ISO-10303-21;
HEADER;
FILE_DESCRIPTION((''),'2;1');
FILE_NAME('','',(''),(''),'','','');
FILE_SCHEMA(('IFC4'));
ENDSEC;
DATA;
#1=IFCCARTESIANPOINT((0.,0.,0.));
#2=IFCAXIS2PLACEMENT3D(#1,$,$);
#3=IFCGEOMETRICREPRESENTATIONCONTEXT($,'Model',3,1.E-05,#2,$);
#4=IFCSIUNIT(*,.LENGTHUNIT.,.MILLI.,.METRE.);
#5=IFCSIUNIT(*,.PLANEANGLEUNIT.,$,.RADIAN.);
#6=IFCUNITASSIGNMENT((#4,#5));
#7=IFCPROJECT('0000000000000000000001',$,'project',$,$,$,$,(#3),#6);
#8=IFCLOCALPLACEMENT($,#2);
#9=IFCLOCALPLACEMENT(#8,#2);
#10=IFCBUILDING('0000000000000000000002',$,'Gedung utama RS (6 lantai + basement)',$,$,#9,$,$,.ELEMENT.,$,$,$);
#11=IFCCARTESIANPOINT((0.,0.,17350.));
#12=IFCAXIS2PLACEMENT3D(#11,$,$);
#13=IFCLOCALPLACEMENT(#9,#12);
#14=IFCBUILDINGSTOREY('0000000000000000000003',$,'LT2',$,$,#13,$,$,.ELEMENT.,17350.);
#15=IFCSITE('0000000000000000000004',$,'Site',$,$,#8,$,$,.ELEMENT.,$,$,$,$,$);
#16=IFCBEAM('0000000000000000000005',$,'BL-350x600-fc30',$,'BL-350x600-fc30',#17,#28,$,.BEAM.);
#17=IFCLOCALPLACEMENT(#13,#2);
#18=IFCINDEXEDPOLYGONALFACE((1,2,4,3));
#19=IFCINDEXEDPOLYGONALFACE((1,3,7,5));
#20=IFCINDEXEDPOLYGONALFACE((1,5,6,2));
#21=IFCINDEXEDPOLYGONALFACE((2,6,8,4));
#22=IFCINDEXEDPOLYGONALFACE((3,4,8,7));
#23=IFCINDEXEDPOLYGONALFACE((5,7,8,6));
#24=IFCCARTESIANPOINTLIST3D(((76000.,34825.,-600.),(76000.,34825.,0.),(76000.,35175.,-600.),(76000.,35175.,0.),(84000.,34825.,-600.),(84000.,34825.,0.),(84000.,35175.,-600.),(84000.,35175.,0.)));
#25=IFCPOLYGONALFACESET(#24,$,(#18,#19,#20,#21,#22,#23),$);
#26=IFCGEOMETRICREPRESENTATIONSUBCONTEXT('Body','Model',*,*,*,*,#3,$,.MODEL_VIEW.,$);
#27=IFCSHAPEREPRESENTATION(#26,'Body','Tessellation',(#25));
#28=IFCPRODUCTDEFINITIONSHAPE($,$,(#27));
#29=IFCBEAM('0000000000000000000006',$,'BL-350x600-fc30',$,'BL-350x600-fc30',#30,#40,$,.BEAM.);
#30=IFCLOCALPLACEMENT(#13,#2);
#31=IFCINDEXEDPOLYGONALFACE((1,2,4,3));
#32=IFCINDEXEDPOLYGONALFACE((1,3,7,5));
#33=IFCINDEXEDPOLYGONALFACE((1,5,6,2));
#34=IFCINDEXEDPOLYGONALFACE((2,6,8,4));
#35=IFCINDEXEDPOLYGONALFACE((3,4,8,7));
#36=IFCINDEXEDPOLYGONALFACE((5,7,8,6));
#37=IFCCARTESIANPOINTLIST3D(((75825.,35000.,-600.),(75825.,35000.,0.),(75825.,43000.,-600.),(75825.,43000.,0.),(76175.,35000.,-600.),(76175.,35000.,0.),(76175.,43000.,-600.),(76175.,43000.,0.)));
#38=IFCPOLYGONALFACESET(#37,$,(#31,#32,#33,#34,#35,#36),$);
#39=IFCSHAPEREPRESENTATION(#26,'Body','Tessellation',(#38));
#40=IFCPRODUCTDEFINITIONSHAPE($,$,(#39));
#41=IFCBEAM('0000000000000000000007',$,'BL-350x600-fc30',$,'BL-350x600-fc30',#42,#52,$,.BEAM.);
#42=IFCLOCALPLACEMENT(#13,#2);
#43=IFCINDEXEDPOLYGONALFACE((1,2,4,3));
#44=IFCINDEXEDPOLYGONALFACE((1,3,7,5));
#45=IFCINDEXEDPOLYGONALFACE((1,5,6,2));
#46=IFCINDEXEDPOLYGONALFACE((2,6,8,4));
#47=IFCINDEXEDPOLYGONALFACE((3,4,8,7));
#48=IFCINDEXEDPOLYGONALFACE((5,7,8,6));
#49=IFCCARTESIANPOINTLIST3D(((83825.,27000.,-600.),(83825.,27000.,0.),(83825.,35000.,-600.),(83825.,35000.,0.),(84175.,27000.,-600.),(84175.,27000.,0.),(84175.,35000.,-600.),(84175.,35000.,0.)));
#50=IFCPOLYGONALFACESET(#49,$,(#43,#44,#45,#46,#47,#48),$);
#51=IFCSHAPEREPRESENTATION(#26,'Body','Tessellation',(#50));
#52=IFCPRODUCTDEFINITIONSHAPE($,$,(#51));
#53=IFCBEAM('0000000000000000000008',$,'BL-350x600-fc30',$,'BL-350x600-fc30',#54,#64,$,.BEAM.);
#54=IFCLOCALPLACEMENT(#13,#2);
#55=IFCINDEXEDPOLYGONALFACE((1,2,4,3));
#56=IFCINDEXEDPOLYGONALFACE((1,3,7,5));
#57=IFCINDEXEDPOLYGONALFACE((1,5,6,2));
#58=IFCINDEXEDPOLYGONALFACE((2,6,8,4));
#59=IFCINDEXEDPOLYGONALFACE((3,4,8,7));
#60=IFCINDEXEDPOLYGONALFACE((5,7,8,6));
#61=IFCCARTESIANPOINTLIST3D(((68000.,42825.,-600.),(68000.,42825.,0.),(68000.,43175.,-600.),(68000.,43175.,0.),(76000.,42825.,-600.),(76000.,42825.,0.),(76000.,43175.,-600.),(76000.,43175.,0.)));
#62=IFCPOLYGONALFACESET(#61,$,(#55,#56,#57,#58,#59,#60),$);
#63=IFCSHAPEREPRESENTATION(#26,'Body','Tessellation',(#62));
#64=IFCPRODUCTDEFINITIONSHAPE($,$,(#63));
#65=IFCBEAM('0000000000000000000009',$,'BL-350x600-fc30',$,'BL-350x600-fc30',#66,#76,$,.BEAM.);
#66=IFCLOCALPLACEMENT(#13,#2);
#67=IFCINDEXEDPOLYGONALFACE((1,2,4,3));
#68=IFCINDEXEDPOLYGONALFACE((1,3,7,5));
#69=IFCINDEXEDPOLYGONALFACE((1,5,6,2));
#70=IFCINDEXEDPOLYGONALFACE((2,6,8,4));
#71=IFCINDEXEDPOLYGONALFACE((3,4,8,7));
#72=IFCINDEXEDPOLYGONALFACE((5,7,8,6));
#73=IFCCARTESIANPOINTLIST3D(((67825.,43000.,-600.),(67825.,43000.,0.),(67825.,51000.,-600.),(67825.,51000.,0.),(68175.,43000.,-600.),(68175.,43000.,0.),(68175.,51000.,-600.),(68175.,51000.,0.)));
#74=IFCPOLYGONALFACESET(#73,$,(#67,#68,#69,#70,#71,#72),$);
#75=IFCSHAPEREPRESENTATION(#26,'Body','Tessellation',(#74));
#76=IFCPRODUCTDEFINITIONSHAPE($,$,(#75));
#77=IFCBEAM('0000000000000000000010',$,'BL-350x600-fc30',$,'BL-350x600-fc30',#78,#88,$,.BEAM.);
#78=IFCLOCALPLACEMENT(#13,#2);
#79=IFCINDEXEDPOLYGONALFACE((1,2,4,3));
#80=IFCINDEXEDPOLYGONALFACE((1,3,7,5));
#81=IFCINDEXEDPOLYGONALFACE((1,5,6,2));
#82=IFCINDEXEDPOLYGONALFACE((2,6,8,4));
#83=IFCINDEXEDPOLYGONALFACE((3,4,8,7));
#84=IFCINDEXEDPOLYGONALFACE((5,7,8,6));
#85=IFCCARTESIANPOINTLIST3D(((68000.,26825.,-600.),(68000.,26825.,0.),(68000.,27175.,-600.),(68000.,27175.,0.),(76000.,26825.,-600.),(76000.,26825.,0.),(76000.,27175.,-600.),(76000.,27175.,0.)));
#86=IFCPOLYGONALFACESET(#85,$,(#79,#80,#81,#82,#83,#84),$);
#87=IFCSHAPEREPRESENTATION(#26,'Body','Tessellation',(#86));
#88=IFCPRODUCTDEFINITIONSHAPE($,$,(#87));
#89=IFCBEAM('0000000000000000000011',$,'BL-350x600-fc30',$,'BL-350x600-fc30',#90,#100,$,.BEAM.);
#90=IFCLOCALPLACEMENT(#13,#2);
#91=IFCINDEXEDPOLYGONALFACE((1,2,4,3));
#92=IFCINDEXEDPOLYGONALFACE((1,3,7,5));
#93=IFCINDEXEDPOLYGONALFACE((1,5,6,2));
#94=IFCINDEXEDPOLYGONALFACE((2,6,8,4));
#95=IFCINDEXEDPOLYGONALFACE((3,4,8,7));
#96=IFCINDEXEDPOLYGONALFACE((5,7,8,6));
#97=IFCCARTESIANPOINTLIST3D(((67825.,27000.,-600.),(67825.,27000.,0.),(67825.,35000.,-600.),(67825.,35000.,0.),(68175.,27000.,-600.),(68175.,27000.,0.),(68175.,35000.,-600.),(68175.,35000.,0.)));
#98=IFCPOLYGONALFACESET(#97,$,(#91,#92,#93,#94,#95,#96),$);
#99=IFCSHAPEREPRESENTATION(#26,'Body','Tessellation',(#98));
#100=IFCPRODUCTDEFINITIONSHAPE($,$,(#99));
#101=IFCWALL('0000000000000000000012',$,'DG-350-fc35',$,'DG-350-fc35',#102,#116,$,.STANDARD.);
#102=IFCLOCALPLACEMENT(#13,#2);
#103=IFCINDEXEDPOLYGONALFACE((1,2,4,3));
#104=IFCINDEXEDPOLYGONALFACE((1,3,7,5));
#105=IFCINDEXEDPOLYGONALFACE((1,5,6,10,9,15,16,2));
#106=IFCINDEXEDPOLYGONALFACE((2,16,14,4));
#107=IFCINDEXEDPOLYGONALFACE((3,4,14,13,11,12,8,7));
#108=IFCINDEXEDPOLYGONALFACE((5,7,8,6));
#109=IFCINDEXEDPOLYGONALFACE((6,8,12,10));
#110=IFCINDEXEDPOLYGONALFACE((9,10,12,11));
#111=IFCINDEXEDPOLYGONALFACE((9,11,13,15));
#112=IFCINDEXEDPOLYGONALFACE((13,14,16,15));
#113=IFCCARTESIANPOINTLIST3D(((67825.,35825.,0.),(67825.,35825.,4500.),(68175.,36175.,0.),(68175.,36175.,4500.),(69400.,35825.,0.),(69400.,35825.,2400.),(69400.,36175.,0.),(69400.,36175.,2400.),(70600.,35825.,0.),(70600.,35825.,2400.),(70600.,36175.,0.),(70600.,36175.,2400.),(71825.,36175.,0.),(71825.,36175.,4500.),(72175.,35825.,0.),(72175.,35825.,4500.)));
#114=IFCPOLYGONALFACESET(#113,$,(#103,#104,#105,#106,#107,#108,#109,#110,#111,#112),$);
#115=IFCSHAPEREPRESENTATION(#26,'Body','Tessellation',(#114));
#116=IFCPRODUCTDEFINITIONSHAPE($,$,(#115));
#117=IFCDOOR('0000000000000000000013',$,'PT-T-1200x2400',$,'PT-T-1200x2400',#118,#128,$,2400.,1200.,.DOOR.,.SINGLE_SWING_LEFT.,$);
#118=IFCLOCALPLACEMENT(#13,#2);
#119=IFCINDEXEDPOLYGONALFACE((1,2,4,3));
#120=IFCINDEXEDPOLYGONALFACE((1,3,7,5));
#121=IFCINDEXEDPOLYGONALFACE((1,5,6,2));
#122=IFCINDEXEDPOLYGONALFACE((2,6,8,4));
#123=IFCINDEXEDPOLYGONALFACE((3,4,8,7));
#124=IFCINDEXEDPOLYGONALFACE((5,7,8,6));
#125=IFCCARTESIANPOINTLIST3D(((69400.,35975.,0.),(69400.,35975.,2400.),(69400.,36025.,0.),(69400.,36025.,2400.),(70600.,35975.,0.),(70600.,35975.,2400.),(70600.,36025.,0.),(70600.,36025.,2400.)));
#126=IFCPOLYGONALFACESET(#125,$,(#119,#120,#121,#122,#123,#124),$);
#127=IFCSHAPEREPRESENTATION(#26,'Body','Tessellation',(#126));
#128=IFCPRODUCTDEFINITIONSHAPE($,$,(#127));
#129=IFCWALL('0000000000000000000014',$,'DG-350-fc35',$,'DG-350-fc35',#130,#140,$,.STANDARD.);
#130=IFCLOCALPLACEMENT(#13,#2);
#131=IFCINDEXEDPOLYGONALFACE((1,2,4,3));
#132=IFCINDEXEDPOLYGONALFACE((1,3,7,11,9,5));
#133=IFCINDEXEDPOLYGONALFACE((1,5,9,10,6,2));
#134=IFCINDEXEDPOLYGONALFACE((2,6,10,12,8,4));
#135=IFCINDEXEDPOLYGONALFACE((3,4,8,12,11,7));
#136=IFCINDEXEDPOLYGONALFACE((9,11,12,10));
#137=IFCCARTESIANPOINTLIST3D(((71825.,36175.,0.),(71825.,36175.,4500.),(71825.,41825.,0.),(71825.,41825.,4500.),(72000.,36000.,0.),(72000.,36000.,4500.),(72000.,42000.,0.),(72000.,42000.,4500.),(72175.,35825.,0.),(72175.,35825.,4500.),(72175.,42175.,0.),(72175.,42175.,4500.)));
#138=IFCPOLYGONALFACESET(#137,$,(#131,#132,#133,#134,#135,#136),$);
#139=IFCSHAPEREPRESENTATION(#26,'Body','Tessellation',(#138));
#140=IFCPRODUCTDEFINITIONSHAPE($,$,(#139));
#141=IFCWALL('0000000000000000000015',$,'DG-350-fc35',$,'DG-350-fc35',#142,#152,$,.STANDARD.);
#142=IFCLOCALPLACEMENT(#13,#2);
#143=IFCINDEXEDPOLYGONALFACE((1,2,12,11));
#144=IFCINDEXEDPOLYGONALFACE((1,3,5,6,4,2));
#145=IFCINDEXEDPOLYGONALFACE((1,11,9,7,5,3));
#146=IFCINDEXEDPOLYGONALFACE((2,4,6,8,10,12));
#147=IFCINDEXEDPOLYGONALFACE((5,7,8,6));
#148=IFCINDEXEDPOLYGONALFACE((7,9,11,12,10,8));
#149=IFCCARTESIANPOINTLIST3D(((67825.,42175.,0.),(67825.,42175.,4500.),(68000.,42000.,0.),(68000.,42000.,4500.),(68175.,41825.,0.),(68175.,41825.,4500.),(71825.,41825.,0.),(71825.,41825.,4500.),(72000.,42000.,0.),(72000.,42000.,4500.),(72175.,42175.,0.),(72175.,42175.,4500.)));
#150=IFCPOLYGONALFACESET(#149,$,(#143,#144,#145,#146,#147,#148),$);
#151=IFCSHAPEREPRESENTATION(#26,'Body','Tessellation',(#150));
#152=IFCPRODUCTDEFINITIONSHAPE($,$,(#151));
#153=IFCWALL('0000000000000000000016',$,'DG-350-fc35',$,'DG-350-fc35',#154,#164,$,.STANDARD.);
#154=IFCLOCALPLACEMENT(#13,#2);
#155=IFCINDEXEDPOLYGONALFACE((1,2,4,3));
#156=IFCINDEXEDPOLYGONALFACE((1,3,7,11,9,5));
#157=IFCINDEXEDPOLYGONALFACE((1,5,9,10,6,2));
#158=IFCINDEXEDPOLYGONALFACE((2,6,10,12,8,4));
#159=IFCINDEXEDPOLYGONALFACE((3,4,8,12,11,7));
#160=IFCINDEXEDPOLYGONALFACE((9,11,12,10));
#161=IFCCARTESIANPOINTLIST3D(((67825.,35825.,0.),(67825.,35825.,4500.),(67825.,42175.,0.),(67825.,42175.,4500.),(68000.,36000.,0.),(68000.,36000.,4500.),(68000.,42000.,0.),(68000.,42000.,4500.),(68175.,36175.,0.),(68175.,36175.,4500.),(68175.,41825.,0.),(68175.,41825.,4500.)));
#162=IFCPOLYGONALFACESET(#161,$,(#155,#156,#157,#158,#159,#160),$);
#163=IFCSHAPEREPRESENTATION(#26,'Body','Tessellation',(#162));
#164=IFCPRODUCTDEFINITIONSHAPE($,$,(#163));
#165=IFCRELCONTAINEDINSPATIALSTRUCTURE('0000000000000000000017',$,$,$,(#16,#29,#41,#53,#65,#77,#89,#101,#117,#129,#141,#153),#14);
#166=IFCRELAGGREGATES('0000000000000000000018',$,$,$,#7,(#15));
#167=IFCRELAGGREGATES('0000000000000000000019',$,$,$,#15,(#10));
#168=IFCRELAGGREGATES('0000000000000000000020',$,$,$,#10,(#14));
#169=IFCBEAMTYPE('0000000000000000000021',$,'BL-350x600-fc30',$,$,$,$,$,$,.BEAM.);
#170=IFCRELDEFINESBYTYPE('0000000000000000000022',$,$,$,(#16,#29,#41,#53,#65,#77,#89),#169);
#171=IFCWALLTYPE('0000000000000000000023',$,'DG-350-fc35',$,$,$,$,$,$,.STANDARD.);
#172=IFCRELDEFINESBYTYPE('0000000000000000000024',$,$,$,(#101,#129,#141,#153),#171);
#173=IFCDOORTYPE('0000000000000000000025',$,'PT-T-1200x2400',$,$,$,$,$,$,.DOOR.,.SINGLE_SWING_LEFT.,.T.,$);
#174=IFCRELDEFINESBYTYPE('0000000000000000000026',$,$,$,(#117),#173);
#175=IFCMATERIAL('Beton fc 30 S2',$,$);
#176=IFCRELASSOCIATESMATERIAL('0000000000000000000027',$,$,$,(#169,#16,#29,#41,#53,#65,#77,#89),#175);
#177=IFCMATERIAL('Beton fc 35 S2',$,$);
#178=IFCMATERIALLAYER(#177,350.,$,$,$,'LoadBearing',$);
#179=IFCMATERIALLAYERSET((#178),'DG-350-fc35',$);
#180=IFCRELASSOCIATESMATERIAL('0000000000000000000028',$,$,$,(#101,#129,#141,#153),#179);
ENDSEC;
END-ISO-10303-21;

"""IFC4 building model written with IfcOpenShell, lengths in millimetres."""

from ifc_helpers import new_model, si_unit, frame, frame_2d, origin, origin_2d, place, context, subcontext, project, spatial, polyline, rectangle, outline, extrude, material, layer, layer_set, layer_usage, material_profile, profile_set, profile_usage, type_object, element, fill, save


model = new_model("IFC4")

# Units and contexts
model_context = context("Model", 3, precision=1e-05, world=origin())
body_context = subcontext(model_context, "Body", "Model", "MODEL_VIEW")
ifc_project = project(units=[si_unit("LENGTHUNIT", "METRE", prefix="MILLI"), si_unit("PLANEANGLEUNIT", "RADIAN")], contexts=[model_context])

# Site, building, storey
site_placement = place(None, origin())
site = spatial("IfcSite", under=ifc_project, at=site_placement, Name="Site", CompositionType="ELEMENT")
building_placement = place(site_placement, origin())
building = spatial("IfcBuilding", under=site, at=building_placement, Name="Gedung utama RS (6 lantai + basement)", CompositionType="ELEMENT")
storey_placement = place(building_placement, frame((0.0, 0.0, 17350.0)))
storey = spatial("IfcBuildingStorey", under=building, at=storey_placement, Name="LT2", CompositionType="ELEMENT", Elevation=17350.0)

# Beams
ifc_material_1 = material(Name="Beton fc 30 S2")
ifc_material_profile_1 = material_profile(ifc_material_1, rectangle(XDim=350.0, YDim=600.0, at=origin_2d()), Name="BL-350x600-fc30")
ifc_profile_set_1 = profile_set([ifc_material_profile_1], Name="BL-350x600-fc30")
ifc_profile_usage_1 = profile_usage(ifc_profile_set_1, cardinal=8)
beam_type = type_object("IfcBeamType", Name="BL-350x600-fc30", PredefinedType="BEAM", material=ifc_profile_set_1)
beam_1_placement = place(storey_placement, frame((76000.0, 35000.0, -300.0)))
element("IfcBeam", 1, at=beam_1_placement, inside=storey, type_object=beam_type, material=ifc_profile_usage_1, Name="BL-350x600-fc30", ObjectType="BL-350x600-fc30", PredefinedType="BEAM", context=body_context, shape_type="SweptSolid", body=[
    extrude(rectangle(XDim=350.0, YDim=600.0, at=origin_2d()), frame((0.0, 0.0, 0.0), z_axis=(1.0, 0.0, 0.0), x_axis=(0.0, 1.0, 0.0)), (0.0, 0.0, 1.0), 8000.0),
])
for number, where, name in (
    (2, (76000.0, 35000.0, -300.0), "BL-350x600-fc30"),
    (3, (84000.0, 27000.0, -300.0), "BL-350x600-fc30"),
):
    element("IfcBeam", number, at=place(storey_placement, frame(where)), inside=storey, type_object=beam_type, material=ifc_profile_usage_1, Name=name, ObjectType="BL-350x600-fc30", PredefinedType="BEAM", context=body_context, shape_type="SweptSolid", body=[
        extrude(rectangle(XDim=350.0, YDim=600.0, at=origin_2d()), frame((0.0, 0.0, 0.0), z_axis=(0.0, 1.0, 0.0), x_axis=(-1.0, 0.0, 0.0)), (0.0, 0.0, 1.0), 8000.0),
    ])
beam_2_placement = place(storey_placement, frame((68000.0, 43000.0, -300.0)))
element("IfcBeam", 4, at=beam_2_placement, inside=storey, type_object=beam_type, material=ifc_profile_usage_1, Name="BL-350x600-fc30", ObjectType="BL-350x600-fc30", PredefinedType="BEAM", context=body_context, shape_type="SweptSolid", body=[
    extrude(rectangle(XDim=350.0, YDim=600.0, at=origin_2d()), frame((0.0, 0.0, 0.0), z_axis=(1.0, 0.0, 0.0), x_axis=(0.0, 1.0, 0.0)), (0.0, 0.0, 1.0), 8000.0),
])
beam_3_placement = place(storey_placement, frame((68000.0, 43000.0, -300.0)))
element("IfcBeam", 5, at=beam_3_placement, inside=storey, type_object=beam_type, material=ifc_profile_usage_1, Name="BL-350x600-fc30", ObjectType="BL-350x600-fc30", PredefinedType="BEAM", context=body_context, shape_type="SweptSolid", body=[
    extrude(rectangle(XDim=350.0, YDim=600.0, at=origin_2d()), frame((0.0, 0.0, 0.0), z_axis=(0.0, 1.0, 0.0), x_axis=(-1.0, 0.0, 0.0)), (0.0, 0.0, 1.0), 8000.0),
])
beam_4_placement = place(storey_placement, frame((68000.0, 27000.0, -300.0)))
element("IfcBeam", 6, at=beam_4_placement, inside=storey, type_object=beam_type, material=ifc_profile_usage_1, Name="BL-350x600-fc30", ObjectType="BL-350x600-fc30", PredefinedType="BEAM", context=body_context, shape_type="SweptSolid", body=[
    extrude(rectangle(XDim=350.0, YDim=600.0, at=origin_2d()), frame((0.0, 0.0, 0.0), z_axis=(1.0, 0.0, 0.0), x_axis=(0.0, 1.0, 0.0)), (0.0, 0.0, 1.0), 8000.0),
])
beam_5_placement = place(storey_placement, frame((68000.0, 27000.0, -300.0)))
element("IfcBeam", 7, at=beam_5_placement, inside=storey, type_object=beam_type, material=ifc_profile_usage_1, Name="BL-350x600-fc30", ObjectType="BL-350x600-fc30", PredefinedType="BEAM", context=body_context, shape_type="SweptSolid", body=[
    extrude(rectangle(XDim=350.0, YDim=600.0, at=origin_2d()), frame((0.0, 0.0, 0.0), z_axis=(0.0, 1.0, 0.0), x_axis=(-1.0, 0.0, 0.0)), (0.0, 0.0, 1.0), 8000.0),
])

# Wall, opening, door
ifc_material_2 = material(Name="Beton fc 35 S2")
ifc_layer = layer(ifc_material_2, 350.0, Category="LoadBearing")
ifc_layer_set = layer_set([ifc_layer], Name="DG-350-fc35")
ifc_layer_usage = layer_usage(ifc_layer_set, "AXIS2", "NEGATIVE", 175.0)
wall_type = type_object("IfcWallType", Name="DG-350-fc35", PredefinedType="STANDARD")
wall_1_placement = place(storey_placement, frame((68000.0, 36000.0, 0.0), z_axis=(0.0, 0.0, 1.0), x_axis=(1.0, 0.0, 0.0)))
wall_1 = element("IfcWall", 8, at=wall_1_placement, inside=storey, type_object=wall_type, material=ifc_layer_usage, Name="DG-350-fc35", ObjectType="DG-350-fc35", PredefinedType="STANDARD", context=body_context, shape_type="SweptSolid", body=[
    extrude(outline(polyline([(-175.0, -175.0), (0.0, 0.0), (175.0, 175.0), (3825.0, 175.0), (4000.0, 0.0), (4175.0, -175.0), (-175.0, -175.0)])), origin(), (0.0, 0.0, 1.0), 4500.0),
])
opening_placement = place(wall_1_placement, frame((1400.0, 0.0, 0.0), z_axis=(0.0, 0.0, 1.0), x_axis=(1.0, 0.0, 0.0)))
opening = element("IfcOpeningElement", 9, at=opening_placement, cuts=wall_1, PredefinedType="OPENING", context=body_context, shape_type="SweptSolid", body=[
    extrude(rectangle(XDim=1200.0, YDim=370.0, at=frame_2d((600.0, 0.0))), origin(), (0.0, 0.0, 1.0), 2400.0),
])
door_type = type_object("IfcDoorType", Name="PT-T-1200x2400", OperationType="SINGLE_SWING_LEFT", ParameterTakesPrecedence=True, PredefinedType="DOOR")
door_placement = place(opening_placement, origin())
door = element("IfcDoor", 10, at=door_placement, inside=storey, type_object=door_type, Name="PT-T-1200x2400", ObjectType="PT-T-1200x2400", OperationType="SINGLE_SWING_LEFT", OverallHeight=2400.0, OverallWidth=1200.0, PredefinedType="DOOR", context=body_context, shape_type="SweptSolid", body=[
    extrude(rectangle(XDim=1200.0, YDim=50.0, at=frame_2d((600.0, 0.0))), origin(), (0.0, 0.0, 1.0), 2400.0),
])
fill(opening, door)

# Walls
wall_2_placement = place(storey_placement, frame((72000.0, 36000.0, 0.0), z_axis=(0.0, 0.0, 1.0), x_axis=(0.0, 1.0, 0.0)))
element("IfcWall", 11, at=wall_2_placement, inside=storey, type_object=wall_type, material=ifc_layer_usage, Name="DG-350-fc35", ObjectType="DG-350-fc35", PredefinedType="STANDARD", context=body_context, shape_type="SweptSolid", body=[
    extrude(outline(polyline([(-175.0, -175.0), (0.0, 0.0), (175.0, 175.0), (5825.0, 175.0), (6000.0, 0.0), (6175.0, -175.0), (-175.0, -175.0)])), origin(), (0.0, 0.0, 1.0), 4500.0),
])
wall_3_placement = place(storey_placement, frame((72000.0, 42000.0, 0.0), z_axis=(0.0, 0.0, 1.0), x_axis=(-1.0, 0.0, 0.0)))
element("IfcWall", 12, at=wall_3_placement, inside=storey, type_object=wall_type, material=ifc_layer_usage, Name="DG-350-fc35", ObjectType="DG-350-fc35", PredefinedType="STANDARD", context=body_context, shape_type="SweptSolid", body=[
    extrude(outline(polyline([(-175.0, -175.0), (0.0, 0.0), (175.0, 175.0), (3825.0, 175.0), (4000.0, 0.0), (4175.0, -175.0), (-175.0, -175.0)])), origin(), (0.0, 0.0, 1.0), 4500.0),
])
wall_4_placement = place(storey_placement, frame((68000.0, 42000.0, 0.0), z_axis=(0.0, 0.0, 1.0), x_axis=(0.0, -1.0, 0.0)))
element("IfcWall", 13, at=wall_4_placement, inside=storey, type_object=wall_type, material=ifc_layer_usage, Name="DG-350-fc35", ObjectType="DG-350-fc35", PredefinedType="STANDARD", context=body_context, shape_type="SweptSolid", body=[
    extrude(outline(polyline([(-175.0, -175.0), (0.0, 0.0), (175.0, 175.0), (5825.0, 175.0), (6000.0, 0.0), (6175.0, -175.0), (-175.0, -175.0)])), origin(), (0.0, 0.0, 1.0), 4500.0),
])

save(model, "model.ifc")
